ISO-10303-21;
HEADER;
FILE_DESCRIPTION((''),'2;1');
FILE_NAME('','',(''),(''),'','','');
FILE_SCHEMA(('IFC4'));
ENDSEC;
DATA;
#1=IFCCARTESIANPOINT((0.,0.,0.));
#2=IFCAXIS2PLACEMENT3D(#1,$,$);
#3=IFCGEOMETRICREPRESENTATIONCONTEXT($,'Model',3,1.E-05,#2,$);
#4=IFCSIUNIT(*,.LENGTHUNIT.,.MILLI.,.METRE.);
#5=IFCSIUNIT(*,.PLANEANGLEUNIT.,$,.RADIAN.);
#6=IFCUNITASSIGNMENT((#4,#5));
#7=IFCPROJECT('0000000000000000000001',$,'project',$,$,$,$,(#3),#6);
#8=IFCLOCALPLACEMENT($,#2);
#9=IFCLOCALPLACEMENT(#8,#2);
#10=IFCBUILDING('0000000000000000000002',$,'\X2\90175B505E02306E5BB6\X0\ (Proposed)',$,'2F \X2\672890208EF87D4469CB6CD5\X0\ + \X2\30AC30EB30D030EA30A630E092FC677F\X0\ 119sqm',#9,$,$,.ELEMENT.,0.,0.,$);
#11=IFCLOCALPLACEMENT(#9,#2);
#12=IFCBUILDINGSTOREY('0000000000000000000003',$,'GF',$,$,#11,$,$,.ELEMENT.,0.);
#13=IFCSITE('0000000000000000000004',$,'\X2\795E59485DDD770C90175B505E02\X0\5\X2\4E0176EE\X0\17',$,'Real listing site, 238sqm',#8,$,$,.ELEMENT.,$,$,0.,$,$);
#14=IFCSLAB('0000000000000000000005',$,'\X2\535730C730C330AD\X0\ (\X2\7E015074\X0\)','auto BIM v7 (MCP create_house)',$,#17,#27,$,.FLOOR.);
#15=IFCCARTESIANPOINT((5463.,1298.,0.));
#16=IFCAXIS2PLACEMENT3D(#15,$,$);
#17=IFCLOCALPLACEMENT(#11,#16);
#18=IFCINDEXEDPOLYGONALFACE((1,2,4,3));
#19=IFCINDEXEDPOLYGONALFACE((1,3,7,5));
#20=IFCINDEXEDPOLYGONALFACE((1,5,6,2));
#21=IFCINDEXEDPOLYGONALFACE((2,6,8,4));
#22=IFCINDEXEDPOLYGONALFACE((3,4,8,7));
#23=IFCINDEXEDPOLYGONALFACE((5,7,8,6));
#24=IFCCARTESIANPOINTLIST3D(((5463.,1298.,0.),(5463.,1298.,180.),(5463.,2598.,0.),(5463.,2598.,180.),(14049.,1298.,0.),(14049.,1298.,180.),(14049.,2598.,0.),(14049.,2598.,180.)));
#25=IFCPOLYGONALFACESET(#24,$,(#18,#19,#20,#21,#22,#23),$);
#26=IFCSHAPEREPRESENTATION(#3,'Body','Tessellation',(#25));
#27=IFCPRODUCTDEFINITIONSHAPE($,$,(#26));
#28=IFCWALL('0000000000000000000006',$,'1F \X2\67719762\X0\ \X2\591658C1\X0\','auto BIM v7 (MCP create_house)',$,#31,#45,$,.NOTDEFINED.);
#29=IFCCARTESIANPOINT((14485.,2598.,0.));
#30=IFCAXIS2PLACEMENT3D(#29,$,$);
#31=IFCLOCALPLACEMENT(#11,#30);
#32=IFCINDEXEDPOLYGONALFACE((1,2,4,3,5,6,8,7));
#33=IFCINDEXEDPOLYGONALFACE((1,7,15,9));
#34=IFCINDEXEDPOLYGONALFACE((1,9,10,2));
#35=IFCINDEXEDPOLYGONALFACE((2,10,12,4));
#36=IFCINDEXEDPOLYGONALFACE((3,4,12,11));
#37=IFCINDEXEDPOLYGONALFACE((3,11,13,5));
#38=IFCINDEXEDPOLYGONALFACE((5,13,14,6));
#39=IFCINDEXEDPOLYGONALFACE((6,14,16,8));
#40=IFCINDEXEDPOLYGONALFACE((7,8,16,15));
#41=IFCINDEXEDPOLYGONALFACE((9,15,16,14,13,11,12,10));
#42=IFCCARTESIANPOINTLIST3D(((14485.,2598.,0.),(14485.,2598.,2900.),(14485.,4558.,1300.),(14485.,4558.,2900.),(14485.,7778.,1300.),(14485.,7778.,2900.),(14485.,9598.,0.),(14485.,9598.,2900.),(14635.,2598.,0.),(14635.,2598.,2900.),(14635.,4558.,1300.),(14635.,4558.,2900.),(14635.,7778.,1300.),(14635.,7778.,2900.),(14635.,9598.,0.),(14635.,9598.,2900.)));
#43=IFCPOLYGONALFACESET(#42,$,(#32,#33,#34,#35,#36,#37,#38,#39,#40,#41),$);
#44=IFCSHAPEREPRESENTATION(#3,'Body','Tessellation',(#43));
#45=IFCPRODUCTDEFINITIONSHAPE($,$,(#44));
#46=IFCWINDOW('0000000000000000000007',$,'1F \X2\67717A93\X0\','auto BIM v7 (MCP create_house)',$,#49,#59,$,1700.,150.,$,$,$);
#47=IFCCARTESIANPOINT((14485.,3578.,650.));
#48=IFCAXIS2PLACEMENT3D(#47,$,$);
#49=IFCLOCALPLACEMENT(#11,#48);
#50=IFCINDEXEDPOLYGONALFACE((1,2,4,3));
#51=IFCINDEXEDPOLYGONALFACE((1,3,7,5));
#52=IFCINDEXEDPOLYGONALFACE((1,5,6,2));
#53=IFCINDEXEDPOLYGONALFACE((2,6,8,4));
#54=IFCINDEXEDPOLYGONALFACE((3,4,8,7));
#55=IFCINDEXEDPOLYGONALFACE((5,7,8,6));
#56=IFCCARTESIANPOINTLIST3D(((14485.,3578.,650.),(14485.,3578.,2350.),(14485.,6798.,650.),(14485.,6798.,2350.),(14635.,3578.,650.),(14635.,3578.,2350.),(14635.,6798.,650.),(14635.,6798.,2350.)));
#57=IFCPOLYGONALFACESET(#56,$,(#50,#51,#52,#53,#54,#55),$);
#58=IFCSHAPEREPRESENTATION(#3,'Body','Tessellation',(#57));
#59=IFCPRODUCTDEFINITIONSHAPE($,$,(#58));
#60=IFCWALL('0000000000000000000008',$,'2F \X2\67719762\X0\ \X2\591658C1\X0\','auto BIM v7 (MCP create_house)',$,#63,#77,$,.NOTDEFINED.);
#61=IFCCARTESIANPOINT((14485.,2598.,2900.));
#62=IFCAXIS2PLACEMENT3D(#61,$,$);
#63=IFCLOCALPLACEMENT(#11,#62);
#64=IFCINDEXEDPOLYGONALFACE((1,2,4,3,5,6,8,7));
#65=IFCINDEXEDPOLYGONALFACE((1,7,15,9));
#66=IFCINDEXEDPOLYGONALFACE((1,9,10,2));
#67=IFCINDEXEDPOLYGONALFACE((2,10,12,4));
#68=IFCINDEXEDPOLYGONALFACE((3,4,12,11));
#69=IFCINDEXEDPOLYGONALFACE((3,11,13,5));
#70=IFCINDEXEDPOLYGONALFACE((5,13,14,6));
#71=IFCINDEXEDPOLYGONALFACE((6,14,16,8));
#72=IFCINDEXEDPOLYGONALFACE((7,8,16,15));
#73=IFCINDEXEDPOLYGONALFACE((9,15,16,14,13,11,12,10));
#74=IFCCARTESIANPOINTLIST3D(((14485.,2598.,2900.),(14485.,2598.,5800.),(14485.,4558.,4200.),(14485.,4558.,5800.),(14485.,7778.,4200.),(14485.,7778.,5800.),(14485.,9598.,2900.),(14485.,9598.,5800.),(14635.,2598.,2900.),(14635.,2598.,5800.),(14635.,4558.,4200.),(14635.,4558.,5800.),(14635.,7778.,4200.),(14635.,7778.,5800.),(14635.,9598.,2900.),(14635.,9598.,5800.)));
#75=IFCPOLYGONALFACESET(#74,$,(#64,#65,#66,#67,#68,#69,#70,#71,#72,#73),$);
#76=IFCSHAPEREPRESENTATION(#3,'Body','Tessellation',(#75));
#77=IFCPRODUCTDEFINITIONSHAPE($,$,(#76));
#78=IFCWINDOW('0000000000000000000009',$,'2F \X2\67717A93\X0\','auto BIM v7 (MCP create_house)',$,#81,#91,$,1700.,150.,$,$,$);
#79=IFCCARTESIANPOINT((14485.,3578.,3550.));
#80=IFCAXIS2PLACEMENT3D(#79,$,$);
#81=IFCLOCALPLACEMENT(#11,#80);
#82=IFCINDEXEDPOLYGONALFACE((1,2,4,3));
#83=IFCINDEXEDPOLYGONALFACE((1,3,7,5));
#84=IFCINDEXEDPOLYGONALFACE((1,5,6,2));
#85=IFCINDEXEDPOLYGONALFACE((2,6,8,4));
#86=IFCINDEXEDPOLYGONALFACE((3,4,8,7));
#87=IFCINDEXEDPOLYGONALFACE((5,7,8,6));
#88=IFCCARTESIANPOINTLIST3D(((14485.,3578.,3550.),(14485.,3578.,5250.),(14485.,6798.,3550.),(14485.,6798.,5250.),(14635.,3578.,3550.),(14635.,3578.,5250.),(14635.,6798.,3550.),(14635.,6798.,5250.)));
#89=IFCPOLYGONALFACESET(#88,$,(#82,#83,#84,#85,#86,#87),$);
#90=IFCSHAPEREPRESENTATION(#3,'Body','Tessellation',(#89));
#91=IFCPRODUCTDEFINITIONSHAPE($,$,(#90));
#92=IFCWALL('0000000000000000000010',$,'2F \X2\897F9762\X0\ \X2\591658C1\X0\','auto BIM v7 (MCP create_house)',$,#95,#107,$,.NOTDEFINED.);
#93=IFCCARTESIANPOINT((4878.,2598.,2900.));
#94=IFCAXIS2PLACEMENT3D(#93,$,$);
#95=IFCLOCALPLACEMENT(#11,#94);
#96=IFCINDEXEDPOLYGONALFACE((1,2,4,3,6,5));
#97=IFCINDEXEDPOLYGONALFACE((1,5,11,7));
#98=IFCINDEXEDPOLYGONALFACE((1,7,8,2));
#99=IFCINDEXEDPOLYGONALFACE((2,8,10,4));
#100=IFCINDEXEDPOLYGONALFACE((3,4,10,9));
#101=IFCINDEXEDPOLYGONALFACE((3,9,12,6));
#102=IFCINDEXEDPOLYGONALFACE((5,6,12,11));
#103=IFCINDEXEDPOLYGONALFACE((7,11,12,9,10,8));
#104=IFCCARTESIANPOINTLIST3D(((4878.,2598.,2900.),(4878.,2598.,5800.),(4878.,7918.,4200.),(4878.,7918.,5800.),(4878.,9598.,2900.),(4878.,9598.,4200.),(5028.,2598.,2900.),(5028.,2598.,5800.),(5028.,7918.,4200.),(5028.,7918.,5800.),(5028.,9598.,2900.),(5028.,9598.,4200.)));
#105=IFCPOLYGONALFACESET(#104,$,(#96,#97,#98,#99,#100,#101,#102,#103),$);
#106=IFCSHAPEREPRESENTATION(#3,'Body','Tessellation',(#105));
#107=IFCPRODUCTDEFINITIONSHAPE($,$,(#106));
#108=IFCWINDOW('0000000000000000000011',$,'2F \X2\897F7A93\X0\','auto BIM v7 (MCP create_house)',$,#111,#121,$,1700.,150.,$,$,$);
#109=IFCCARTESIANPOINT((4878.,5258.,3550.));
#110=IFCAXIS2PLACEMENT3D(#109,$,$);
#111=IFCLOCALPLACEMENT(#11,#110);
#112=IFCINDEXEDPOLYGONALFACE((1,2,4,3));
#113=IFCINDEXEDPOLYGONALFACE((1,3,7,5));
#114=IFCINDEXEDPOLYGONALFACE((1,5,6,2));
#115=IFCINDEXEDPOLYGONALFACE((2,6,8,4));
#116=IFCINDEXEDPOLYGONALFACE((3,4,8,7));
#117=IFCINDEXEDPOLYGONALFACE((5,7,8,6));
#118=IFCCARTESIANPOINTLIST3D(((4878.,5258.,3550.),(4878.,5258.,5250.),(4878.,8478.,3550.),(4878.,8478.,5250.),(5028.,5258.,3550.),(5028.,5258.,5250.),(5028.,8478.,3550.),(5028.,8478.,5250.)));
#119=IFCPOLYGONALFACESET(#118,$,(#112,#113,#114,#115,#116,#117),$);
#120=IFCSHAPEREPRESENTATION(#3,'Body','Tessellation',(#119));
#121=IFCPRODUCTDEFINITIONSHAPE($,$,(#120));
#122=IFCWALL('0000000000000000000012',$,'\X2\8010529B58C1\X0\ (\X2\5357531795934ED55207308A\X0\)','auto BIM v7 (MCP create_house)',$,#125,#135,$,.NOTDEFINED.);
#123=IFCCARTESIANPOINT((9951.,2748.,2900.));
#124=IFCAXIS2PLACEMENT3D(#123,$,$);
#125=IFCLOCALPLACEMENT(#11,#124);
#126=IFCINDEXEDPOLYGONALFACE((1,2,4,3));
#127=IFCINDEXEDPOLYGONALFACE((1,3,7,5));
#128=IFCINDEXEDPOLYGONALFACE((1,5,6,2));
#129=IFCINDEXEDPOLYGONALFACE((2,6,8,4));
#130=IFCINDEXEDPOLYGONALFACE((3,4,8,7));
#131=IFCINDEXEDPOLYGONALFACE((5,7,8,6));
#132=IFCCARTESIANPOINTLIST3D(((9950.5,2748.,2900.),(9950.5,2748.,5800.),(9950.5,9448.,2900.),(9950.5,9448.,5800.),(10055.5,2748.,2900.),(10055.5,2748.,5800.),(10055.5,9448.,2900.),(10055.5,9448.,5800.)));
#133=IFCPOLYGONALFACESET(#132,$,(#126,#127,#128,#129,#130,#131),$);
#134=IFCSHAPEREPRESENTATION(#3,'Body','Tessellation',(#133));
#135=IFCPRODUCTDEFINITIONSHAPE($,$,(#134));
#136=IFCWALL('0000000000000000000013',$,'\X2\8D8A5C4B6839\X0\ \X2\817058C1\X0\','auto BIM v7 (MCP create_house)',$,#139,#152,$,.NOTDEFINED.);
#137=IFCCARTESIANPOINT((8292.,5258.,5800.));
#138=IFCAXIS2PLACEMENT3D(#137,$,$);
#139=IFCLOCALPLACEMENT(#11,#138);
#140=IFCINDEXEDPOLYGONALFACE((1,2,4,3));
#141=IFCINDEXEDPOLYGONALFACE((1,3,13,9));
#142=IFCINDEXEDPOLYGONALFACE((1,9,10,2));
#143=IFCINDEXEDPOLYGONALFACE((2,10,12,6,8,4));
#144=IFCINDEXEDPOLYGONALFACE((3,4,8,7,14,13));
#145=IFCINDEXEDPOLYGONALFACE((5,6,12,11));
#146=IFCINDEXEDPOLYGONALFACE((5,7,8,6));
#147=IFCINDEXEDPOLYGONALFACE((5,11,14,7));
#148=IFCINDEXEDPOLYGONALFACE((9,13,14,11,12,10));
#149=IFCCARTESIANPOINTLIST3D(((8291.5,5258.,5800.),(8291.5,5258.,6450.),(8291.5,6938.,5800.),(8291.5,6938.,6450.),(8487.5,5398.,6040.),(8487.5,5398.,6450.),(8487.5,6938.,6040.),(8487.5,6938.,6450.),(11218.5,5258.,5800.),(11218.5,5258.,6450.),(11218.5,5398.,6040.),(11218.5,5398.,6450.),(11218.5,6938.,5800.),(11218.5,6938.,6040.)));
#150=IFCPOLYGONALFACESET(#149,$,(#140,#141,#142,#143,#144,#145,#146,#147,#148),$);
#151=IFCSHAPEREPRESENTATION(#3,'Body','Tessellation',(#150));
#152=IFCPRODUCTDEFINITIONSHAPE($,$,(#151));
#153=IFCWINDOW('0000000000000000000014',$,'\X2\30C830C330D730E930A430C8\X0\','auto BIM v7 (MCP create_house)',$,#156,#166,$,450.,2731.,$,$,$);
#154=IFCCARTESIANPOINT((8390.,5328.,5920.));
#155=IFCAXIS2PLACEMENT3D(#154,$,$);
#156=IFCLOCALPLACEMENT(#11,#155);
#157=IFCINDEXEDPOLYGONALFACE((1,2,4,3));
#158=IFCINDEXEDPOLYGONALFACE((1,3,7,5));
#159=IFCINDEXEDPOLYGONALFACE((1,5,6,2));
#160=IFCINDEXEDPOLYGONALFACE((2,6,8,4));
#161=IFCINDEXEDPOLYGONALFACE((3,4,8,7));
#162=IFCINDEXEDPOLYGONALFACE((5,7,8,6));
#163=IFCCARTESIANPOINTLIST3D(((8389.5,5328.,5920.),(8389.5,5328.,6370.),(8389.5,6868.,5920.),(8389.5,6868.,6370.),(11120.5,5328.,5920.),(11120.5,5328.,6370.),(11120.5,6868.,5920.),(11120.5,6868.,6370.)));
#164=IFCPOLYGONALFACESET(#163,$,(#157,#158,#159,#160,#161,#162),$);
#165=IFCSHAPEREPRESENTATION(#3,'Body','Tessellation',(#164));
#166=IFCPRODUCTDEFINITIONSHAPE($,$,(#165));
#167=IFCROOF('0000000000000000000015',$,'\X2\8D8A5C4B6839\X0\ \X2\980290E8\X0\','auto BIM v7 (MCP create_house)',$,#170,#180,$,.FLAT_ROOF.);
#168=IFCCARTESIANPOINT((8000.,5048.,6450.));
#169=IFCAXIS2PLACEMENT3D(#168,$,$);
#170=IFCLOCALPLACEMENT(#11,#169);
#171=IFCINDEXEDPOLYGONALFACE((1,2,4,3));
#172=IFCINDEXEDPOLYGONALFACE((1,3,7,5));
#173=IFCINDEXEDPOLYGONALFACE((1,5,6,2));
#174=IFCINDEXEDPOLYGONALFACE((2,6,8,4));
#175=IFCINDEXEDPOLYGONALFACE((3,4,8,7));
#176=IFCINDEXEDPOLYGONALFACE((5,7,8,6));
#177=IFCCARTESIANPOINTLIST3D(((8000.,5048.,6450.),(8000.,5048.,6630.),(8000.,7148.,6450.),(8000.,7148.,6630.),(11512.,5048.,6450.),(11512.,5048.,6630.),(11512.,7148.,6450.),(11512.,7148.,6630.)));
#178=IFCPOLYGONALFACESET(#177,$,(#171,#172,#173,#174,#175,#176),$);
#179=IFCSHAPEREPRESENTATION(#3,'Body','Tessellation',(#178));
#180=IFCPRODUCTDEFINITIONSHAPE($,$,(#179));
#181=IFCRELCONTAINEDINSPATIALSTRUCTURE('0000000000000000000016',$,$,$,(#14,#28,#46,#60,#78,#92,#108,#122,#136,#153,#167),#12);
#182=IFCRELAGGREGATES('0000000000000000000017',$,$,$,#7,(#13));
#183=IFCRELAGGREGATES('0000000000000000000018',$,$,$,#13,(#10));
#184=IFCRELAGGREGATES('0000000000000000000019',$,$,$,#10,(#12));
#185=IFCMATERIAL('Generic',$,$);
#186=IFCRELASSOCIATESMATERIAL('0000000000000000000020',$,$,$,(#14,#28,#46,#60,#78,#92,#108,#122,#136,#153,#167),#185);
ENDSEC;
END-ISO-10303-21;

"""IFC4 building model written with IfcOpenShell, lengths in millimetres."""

from ifc_helpers import new_model, si_unit, frame, frame_2d, origin, place, context, project, spatial, rectangle, extrude, material, element, fill, save


model = new_model("IFC4")

# Units and contexts
model_context = context("Model", 3, precision=1e-05, world=origin())
ifc_project = project(units=[si_unit("LENGTHUNIT", "METRE", prefix="MILLI"), si_unit("PLANEANGLEUNIT", "RADIAN")], contexts=[model_context])

# Site, building, storey
site_placement = place(None, origin())
site = spatial("IfcSite", under=ifc_project, at=site_placement, Name="神奈川県逗子市5丁目17", ObjectType="Real listing site, 238sqm", CompositionType="ELEMENT", RefElevation=0.0)
building_placement = place(site_placement, origin())
building = spatial("IfcBuilding", under=site, at=building_placement, Name="逗子市の家 (Proposed)", ObjectType="2F 木造軸組構法 + ガルバリウム鋼板 119sqm", CompositionType="ELEMENT", ElevationOfRefHeight=0.0, ElevationOfTerrain=0.0)
storey_placement = place(building_placement, origin())
storey = spatial("IfcBuildingStorey", under=building, at=storey_placement, Name="GF", CompositionType="ELEMENT", Elevation=0.0)

# Slab
ifc_material = material(Name="Generic")
slab_placement = place(storey_placement, frame((5463.0, 1298.0, 0.0)))
element("IfcSlab", 1, at=slab_placement, inside=storey, material=ifc_material, Name="南デッキ (縁側)", Description="auto BIM v7 (MCP create_house)", PredefinedType="FLOOR", context=model_context, shape_type="SweptSolid", body=[
    extrude(rectangle(XDim=8586.0, YDim=1300.0, at=frame_2d((4293.0, 650.0))), frame((5463.0, 1298.0, 0.0)), (0.0, 0.0, 1.0), 180.0),
])

# Wall, opening, window
wall_1_placement = place(storey_placement, frame((14485.0, 2598.0, 0.0)))
wall_1 = element("IfcWall", 2, at=wall_1_placement, inside=storey, material=ifc_material, Name="1F 東面 外壁", Description="auto BIM v7 (MCP create_house)", PredefinedType="NOTDEFINED", context=model_context, shape_type="SweptSolid", body=[
    extrude(rectangle(XDim=150.0, YDim=7000.0, at=frame_2d((75.0, 3500.0))), frame((14485.0, 2598.0, 0.0)), (0.0, 0.0, 1.0), 2900.0),
])
opening_1_placement = place(storey_placement, frame((14485.0, 3578.0, 650.0)))
opening_1 = element("IfcOpeningElement", 3, at=opening_1_placement, cuts=wall_1, PredefinedType="NOTDEFINED", context=model_context, shape_type="SweptSolid", body=[
    extrude(rectangle(XDim=150.0, YDim=3220.0, at=frame_2d((75.0, 1610.0))), frame((14485.0, 3578.0, 650.0)), (0.0, 0.0, 1.0), 1700.0),
])
window_1_placement = place(storey_placement, frame((14485.0, 3578.0, 650.0)))
window_1 = element("IfcWindow", 4, at=window_1_placement, inside=storey, material=ifc_material, Name="1F 東窓", Description="auto BIM v7 (MCP create_house)", OverallHeight=1700.0, OverallWidth=150.0, context=model_context, shape_type="SweptSolid", body=[
    extrude(rectangle(XDim=150.0, YDim=3220.0, at=frame_2d((75.0, 1610.0))), frame((14485.0, 3578.0, 650.0)), (0.0, 0.0, 1.0), 1700.0),
])
fill(opening_1, window_1)

# Walls, openings, windows
wall_2_placement = place(storey_placement, frame((14485.0, 2598.0, 2900.0)))
wall_2 = element("IfcWall", 5, at=wall_2_placement, inside=storey, material=ifc_material, Name="2F 東面 外壁", Description="auto BIM v7 (MCP create_house)", PredefinedType="NOTDEFINED", context=model_context, shape_type="SweptSolid", body=[
    extrude(rectangle(XDim=150.0, YDim=7000.0, at=frame_2d((75.0, 3500.0))), frame((14485.0, 2598.0, 2900.0)), (0.0, 0.0, 1.0), 2900.0),
])
opening_2_placement = place(storey_placement, frame((14485.0, 3578.0, 3550.0)))
opening_2 = element("IfcOpeningElement", 6, at=opening_2_placement, cuts=wall_2, PredefinedType="NOTDEFINED", context=model_context, shape_type="SweptSolid", body=[
    extrude(rectangle(XDim=150.0, YDim=3220.0, at=frame_2d((75.0, 1610.0))), frame((14485.0, 3578.0, 3550.0)), (0.0, 0.0, 1.0), 1700.0),
])
window_2_placement = place(storey_placement, frame((14485.0, 3578.0, 3550.0)))
window_2 = element("IfcWindow", 7, at=window_2_placement, inside=storey, material=ifc_material, Name="2F 東窓", Description="auto BIM v7 (MCP create_house)", OverallHeight=1700.0, OverallWidth=150.0, context=model_context, shape_type="SweptSolid", body=[
    extrude(rectangle(XDim=150.0, YDim=3220.0, at=frame_2d((75.0, 1610.0))), frame((14485.0, 3578.0, 3550.0)), (0.0, 0.0, 1.0), 1700.0),
])
fill(opening_2, window_2)
wall_3_placement = place(storey_placement, frame((4878.0, 2598.0, 2900.0)))
wall_3 = element("IfcWall", 8, at=wall_3_placement, inside=storey, material=ifc_material, Name="2F 西面 外壁", Description="auto BIM v7 (MCP create_house)", PredefinedType="NOTDEFINED", context=model_context, shape_type="SweptSolid", body=[
    extrude(rectangle(XDim=150.0, YDim=7000.0, at=frame_2d((75.0, 3500.0))), frame((4878.0, 2598.0, 2900.0)), (0.0, 0.0, 1.0), 2900.0),
])
opening_3_placement = place(storey_placement, frame((4878.0, 5258.0, 3550.0)))
opening_3 = element("IfcOpeningElement", 9, at=opening_3_placement, cuts=wall_3, PredefinedType="NOTDEFINED", context=model_context, shape_type="SweptSolid", body=[
    extrude(rectangle(XDim=150.0, YDim=3220.0, at=frame_2d((75.0, 1610.0))), frame((4878.0, 5258.0, 3550.0)), (0.0, 0.0, 1.0), 1700.0),
])
window_3_placement = place(storey_placement, frame((4878.0, 5258.0, 3550.0)))
window_3 = element("IfcWindow", 10, at=window_3_placement, inside=storey, material=ifc_material, Name="2F 西窓", Description="auto BIM v7 (MCP create_house)", OverallHeight=1700.0, OverallWidth=150.0, context=model_context, shape_type="SweptSolid", body=[
    extrude(rectangle(XDim=150.0, YDim=3220.0, at=frame_2d((75.0, 1610.0))), frame((4878.0, 5258.0, 3550.0)), (0.0, 0.0, 1.0), 1700.0),
])
fill(opening_3, window_3)

# Wall
wall_4_placement = place(storey_placement, frame((9951.0, 2748.0, 2900.0)))
element("IfcWall", 11, at=wall_4_placement, inside=storey, material=ifc_material, Name="耐力壁 (南北間仕切り)", Description="auto BIM v7 (MCP create_house)", PredefinedType="NOTDEFINED", context=model_context, shape_type="SweptSolid", body=[
    extrude(rectangle(XDim=105.0, YDim=6700.0, at=frame_2d((52.0, 3350.0))), frame((9951.0, 2748.0, 2900.0)), (0.0, 0.0, 1.0), 2900.0),
])

# Wall, opening, window
wall_5_placement = place(storey_placement, frame((8292.0, 5258.0, 5800.0)))
wall_5 = element("IfcWall", 12, at=wall_5_placement, inside=storey, material=ifc_material, Name="越屋根 腰壁", Description="auto BIM v7 (MCP create_house)", PredefinedType="NOTDEFINED", context=model_context, shape_type="SweptSolid", body=[
    extrude(rectangle(XDim=2927.0, YDim=1680.0, at=frame_2d((1463.0, 840.0))), frame((8292.0, 5258.0, 5800.0)), (0.0, 0.0, 1.0), 650.0),
])
opening_4_placement = place(storey_placement, frame((8390.0, 5328.0, 5920.0)))
opening_4 = element("IfcOpeningElement", 13, at=opening_4_placement, cuts=wall_5, PredefinedType="NOTDEFINED", context=model_context, shape_type="SweptSolid", body=[
    extrude(rectangle(XDim=2731.0, YDim=1540.0, at=frame_2d((1365.0, 770.0))), frame((8390.0, 5328.0, 5920.0)), (0.0, 0.0, 1.0), 450.0),
])
window_4_placement = place(storey_placement, frame((8390.0, 5328.0, 5920.0)))
window_4 = element("IfcWindow", 14, at=window_4_placement, inside=storey, material=ifc_material, Name="トップライト", Description="auto BIM v7 (MCP create_house)", OverallHeight=450.0, OverallWidth=2731.0, context=model_context, shape_type="SweptSolid", body=[
    extrude(rectangle(XDim=2731.0, YDim=1540.0, at=frame_2d((1365.0, 770.0))), frame((8390.0, 5328.0, 5920.0)), (0.0, 0.0, 1.0), 450.0),
])
fill(opening_4, window_4)

# Roof
roof_placement = place(storey_placement, frame((8000.0, 5048.0, 6450.0)))
element("IfcRoof", 15, at=roof_placement, inside=storey, material=ifc_material, Name="越屋根 頂部", Description="auto BIM v7 (MCP create_house)", PredefinedType="FLAT_ROOF", context=model_context, shape_type="SweptSolid", body=[
    extrude(rectangle(XDim=3512.0, YDim=2100.0, at=frame_2d((1756.0, 1050.0))), frame((8000.0, 5048.0, 6450.0)), (0.0, 0.0, 1.0), 180.0),
])

save(model, "model.ifc")
